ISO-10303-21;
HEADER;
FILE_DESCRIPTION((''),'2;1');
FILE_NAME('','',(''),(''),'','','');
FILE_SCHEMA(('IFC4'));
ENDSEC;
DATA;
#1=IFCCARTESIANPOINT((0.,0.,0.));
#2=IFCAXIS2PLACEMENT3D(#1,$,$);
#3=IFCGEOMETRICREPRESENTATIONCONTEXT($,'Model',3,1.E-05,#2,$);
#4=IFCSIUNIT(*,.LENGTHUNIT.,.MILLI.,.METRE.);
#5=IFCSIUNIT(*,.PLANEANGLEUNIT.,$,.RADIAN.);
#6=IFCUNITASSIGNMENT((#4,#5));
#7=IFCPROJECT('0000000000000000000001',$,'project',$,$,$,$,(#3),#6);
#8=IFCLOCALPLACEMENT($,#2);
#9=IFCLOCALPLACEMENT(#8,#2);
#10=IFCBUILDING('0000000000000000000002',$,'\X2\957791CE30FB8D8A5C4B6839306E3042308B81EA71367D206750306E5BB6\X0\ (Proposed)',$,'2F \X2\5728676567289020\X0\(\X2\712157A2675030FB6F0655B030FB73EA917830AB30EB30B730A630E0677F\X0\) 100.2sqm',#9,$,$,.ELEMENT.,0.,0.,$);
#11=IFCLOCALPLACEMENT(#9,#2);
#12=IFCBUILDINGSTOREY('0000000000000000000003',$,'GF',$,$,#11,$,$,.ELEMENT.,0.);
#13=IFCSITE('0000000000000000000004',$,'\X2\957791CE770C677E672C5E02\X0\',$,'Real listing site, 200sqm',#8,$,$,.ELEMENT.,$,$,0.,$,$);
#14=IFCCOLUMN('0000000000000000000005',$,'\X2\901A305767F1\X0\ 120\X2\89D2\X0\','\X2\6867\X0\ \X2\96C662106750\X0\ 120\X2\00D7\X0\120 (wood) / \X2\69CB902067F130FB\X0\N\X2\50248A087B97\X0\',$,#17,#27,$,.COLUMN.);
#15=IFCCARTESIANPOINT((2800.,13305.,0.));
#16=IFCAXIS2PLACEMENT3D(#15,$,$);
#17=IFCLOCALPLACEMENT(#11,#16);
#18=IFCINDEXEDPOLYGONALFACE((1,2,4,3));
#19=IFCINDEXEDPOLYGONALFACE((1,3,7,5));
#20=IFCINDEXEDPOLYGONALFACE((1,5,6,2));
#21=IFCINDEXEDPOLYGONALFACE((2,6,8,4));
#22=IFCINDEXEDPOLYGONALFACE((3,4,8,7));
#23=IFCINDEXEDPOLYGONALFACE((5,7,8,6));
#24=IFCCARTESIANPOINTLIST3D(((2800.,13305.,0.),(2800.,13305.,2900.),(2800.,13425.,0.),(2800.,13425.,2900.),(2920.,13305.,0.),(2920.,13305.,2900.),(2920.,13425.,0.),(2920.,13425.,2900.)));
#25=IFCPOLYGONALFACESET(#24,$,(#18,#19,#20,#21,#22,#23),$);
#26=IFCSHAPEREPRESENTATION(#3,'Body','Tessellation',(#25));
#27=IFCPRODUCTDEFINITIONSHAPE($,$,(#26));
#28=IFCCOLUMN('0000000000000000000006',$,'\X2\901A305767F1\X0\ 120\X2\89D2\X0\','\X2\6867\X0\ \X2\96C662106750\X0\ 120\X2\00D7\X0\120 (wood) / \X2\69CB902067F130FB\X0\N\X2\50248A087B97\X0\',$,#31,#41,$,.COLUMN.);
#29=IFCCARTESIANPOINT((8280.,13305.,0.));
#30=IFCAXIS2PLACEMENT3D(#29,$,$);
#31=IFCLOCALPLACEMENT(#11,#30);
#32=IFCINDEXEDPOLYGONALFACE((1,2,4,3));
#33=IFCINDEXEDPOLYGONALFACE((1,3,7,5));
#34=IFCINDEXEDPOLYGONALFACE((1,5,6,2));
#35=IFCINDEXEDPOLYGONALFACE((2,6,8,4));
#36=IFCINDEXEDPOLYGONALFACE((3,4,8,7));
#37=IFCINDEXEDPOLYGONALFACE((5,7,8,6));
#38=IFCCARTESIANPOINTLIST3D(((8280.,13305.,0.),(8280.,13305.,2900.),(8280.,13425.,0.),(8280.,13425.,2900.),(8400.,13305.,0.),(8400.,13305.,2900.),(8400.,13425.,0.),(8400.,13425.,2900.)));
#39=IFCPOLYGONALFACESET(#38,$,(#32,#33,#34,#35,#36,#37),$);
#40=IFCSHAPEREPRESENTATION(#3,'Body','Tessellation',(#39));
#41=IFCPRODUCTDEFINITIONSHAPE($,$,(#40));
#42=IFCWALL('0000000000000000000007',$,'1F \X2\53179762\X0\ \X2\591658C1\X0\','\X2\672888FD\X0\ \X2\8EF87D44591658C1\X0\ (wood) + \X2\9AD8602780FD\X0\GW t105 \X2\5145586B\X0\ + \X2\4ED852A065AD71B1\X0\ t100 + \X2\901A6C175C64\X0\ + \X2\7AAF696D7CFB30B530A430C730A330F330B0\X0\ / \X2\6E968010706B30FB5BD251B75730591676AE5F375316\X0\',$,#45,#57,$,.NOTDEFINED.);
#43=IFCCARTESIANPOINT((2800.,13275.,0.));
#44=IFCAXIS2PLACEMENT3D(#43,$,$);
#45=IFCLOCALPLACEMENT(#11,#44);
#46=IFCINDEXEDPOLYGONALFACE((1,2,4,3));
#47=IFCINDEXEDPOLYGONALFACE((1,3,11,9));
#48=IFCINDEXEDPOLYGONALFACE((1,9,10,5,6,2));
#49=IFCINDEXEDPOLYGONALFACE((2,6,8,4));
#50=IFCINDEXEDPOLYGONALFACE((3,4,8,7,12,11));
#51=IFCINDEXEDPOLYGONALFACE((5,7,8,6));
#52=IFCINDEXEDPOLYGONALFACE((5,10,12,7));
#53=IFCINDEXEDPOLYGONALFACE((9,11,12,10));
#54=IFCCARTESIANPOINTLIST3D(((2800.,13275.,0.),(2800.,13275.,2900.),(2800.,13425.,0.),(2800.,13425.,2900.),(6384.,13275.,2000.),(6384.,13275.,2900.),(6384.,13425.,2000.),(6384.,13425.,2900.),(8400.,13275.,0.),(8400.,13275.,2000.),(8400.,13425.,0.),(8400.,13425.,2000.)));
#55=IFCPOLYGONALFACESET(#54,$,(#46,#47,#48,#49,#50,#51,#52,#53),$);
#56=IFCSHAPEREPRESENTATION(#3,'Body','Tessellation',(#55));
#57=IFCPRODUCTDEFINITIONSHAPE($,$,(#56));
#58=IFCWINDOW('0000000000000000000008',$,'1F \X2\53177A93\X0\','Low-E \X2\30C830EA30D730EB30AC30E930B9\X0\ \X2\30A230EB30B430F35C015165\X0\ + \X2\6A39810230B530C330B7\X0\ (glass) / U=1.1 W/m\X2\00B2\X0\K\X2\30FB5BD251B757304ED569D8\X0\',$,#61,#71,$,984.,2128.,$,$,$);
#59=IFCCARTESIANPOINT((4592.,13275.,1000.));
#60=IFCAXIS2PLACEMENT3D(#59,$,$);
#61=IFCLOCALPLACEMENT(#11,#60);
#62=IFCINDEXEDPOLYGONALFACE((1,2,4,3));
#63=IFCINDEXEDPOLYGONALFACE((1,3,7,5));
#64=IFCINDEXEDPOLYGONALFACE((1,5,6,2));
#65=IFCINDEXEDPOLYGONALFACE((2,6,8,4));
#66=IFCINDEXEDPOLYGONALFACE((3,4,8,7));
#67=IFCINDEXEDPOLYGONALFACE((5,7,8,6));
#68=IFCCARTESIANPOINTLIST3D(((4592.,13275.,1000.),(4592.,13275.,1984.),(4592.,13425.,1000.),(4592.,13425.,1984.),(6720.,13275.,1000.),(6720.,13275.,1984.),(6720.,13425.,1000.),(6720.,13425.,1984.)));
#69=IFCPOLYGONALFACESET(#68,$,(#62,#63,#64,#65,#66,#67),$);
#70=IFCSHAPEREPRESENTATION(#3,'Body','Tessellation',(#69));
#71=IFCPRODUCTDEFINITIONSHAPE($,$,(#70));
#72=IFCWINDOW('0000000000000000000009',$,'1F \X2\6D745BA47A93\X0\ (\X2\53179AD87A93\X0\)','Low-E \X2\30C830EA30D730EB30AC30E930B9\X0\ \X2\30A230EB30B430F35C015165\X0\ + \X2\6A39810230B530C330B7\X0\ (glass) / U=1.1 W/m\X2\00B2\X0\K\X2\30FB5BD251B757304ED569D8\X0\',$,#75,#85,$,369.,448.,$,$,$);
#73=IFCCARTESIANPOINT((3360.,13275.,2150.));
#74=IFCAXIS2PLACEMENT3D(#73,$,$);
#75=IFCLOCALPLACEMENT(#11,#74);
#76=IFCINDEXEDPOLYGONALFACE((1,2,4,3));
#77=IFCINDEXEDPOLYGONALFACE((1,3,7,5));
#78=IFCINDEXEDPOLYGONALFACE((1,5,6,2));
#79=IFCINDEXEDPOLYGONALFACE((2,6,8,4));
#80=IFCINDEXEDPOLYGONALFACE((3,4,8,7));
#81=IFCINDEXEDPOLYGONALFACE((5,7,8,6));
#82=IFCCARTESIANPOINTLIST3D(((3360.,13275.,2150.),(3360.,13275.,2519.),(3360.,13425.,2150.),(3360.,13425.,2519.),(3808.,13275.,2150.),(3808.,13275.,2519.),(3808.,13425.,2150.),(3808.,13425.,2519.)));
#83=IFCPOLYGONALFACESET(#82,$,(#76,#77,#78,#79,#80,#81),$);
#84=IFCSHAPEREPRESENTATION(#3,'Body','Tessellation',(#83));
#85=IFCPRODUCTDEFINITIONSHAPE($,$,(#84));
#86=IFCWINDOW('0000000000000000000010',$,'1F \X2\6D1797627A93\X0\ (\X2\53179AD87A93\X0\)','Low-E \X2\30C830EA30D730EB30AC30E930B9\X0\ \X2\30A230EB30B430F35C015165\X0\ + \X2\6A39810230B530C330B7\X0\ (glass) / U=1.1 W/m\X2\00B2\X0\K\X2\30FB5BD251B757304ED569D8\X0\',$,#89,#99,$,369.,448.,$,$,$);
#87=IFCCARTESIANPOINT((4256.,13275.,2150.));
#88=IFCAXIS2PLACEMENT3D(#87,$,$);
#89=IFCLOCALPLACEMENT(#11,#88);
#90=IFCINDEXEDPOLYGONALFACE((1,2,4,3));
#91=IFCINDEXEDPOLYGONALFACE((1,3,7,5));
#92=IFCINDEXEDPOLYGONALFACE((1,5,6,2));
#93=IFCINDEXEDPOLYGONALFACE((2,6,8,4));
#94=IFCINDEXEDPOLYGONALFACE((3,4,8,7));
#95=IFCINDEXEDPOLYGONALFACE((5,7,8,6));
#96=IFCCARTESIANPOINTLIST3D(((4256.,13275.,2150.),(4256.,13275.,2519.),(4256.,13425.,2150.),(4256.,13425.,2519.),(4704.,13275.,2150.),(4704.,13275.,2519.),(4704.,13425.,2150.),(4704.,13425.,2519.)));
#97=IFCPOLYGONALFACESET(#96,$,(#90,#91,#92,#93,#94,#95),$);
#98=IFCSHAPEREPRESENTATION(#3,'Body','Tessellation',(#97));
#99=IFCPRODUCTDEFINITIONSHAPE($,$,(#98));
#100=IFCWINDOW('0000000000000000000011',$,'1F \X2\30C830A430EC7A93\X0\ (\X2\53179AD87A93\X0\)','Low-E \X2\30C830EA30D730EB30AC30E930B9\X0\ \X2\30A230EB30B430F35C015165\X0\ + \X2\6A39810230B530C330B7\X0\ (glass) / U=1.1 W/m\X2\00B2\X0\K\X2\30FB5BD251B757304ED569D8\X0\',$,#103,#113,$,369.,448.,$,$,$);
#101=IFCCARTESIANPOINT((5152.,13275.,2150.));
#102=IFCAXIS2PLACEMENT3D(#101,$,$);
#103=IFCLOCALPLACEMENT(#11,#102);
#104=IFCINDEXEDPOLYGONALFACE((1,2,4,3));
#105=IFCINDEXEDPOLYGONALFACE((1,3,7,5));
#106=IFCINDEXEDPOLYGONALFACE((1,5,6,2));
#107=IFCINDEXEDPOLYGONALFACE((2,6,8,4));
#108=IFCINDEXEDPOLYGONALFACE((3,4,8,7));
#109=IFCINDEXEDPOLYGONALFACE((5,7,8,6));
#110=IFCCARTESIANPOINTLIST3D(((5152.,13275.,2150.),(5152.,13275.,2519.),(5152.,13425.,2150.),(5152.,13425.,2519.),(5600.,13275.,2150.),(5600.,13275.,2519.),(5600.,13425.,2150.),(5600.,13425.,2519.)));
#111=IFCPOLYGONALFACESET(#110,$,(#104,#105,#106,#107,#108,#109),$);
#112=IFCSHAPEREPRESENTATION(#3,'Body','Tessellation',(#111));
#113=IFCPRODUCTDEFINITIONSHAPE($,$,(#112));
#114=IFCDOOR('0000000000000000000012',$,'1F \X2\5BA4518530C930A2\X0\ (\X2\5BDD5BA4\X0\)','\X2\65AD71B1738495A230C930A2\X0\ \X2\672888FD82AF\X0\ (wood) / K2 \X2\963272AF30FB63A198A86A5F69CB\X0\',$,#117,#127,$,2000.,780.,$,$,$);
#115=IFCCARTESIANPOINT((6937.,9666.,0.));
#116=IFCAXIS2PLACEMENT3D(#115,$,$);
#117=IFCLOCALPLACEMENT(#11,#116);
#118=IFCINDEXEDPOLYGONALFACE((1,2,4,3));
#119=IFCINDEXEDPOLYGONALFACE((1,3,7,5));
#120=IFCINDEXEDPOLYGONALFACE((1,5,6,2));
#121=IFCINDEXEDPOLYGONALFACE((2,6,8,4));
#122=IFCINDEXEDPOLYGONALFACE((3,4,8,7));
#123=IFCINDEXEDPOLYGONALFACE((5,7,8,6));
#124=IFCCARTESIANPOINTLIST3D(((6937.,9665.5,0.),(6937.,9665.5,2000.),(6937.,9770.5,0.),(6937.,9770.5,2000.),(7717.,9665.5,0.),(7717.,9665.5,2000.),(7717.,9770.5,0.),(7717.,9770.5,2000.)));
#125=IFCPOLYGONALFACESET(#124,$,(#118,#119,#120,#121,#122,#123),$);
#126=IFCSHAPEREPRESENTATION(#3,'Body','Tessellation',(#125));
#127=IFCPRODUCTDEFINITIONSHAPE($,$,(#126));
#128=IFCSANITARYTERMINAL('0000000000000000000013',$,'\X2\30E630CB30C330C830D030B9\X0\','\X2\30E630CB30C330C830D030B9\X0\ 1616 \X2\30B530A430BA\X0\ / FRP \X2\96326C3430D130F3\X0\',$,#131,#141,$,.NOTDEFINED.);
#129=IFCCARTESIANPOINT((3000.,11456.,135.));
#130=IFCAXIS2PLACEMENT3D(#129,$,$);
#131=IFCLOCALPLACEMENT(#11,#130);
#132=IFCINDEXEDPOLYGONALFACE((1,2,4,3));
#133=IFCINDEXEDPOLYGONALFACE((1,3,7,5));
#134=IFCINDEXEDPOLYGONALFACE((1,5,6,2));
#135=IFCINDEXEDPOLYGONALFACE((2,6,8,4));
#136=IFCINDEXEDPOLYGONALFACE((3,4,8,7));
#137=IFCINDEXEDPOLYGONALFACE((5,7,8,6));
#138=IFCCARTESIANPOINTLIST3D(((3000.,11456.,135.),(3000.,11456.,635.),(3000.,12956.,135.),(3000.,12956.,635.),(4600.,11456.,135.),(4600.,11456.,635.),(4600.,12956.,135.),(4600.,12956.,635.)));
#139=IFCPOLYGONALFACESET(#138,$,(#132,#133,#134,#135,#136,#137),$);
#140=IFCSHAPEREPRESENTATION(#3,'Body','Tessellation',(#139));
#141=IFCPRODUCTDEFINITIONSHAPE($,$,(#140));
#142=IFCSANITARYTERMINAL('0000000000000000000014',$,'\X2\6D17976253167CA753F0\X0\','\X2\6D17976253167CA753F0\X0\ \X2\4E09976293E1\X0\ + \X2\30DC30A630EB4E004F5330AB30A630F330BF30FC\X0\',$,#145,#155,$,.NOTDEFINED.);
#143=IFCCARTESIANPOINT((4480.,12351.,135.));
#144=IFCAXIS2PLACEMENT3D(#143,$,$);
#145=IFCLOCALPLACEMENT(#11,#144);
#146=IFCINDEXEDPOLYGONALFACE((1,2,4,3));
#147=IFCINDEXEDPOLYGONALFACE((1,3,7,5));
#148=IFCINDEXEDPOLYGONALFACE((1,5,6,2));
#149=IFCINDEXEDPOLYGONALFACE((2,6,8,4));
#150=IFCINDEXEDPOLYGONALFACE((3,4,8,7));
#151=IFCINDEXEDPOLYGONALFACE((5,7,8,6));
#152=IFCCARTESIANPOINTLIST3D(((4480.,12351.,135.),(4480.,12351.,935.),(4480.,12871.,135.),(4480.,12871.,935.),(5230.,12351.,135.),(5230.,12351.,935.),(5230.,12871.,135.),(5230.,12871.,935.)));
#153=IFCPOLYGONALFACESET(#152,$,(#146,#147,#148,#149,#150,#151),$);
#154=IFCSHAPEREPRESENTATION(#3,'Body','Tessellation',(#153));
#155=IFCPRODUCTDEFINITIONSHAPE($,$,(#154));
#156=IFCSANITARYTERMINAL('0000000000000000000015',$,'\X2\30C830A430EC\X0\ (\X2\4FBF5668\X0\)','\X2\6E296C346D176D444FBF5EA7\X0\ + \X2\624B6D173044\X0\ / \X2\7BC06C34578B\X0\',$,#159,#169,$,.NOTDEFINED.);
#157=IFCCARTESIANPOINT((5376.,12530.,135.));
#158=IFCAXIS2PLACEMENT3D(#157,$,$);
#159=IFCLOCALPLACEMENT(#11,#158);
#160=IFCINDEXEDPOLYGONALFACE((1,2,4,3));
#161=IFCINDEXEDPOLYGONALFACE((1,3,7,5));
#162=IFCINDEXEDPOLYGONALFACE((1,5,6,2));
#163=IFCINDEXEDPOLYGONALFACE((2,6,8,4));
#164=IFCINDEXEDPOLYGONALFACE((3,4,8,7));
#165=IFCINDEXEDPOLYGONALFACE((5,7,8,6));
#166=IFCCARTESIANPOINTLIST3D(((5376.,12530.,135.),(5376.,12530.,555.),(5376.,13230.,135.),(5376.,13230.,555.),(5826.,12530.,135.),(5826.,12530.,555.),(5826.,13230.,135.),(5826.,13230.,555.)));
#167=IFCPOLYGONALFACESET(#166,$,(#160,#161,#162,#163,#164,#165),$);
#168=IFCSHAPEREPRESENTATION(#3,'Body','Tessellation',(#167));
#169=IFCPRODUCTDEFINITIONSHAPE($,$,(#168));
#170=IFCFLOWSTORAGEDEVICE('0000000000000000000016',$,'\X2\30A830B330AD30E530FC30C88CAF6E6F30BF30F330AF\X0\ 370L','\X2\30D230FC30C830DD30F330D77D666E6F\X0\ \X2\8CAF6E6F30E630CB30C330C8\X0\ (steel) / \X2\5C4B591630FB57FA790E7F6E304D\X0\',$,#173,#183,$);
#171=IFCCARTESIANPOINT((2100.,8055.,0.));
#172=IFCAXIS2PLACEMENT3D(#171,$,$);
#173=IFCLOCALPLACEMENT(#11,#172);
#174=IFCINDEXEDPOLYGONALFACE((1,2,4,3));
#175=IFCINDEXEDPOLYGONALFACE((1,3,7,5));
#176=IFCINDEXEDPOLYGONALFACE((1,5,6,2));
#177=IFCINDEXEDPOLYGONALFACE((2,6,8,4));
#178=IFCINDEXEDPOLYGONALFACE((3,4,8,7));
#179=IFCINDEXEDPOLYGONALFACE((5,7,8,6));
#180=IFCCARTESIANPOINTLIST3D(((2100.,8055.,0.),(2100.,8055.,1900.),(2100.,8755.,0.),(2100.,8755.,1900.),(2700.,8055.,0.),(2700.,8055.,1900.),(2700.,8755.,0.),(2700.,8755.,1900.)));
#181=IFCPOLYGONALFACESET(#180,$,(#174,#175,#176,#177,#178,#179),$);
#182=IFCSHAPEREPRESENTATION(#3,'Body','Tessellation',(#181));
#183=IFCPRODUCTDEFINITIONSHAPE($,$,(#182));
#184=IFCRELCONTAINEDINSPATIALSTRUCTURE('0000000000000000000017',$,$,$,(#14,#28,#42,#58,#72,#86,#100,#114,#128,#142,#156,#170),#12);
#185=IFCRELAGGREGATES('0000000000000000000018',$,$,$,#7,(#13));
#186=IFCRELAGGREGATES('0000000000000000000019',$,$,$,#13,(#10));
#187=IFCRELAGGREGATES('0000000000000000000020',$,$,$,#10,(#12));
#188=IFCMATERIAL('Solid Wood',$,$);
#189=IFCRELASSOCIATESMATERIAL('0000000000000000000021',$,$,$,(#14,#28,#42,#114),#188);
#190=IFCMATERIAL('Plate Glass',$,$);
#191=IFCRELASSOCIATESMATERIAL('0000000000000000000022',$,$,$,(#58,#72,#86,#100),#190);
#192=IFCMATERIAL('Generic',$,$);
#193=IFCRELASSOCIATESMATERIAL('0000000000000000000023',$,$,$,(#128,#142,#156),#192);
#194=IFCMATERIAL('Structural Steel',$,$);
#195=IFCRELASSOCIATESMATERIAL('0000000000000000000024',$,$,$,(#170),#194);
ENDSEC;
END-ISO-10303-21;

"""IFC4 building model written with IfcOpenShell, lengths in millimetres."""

from ifc_helpers import new_model, si_unit, frame, frame_2d, origin, place, context, project, spatial, rectangle, extrude, material, element, fill, save


model = new_model("IFC4")

# Units and contexts
model_context = context("Model", 3, precision=1e-05, world=origin())
ifc_project = project(units=[si_unit("LENGTHUNIT", "METRE", prefix="MILLI"), si_unit("PLANEANGLEUNIT", "RADIAN")], contexts=[model_context])

# Site, building, storey
site_placement = place(None, origin())
site = spatial("IfcSite", under=ifc_project, at=site_placement, Name="長野県松本市", ObjectType="Real listing site, 200sqm", CompositionType="ELEMENT", RefElevation=0.0)
building_placement = place(site_placement, origin())
building = spatial("IfcBuilding", under=site, at=building_placement, Name="長野・越屋根のある自然素材の家 (Proposed)", ObjectType="2F 在来木造(無垢材・漆喰・珪酸カルシウム板) 100.2sqm", CompositionType="ELEMENT", ElevationOfRefHeight=0.0, ElevationOfTerrain=0.0)
storey_placement = place(building_placement, origin())
storey = spatial("IfcBuildingStorey", under=building, at=storey_placement, Name="GF", CompositionType="ELEMENT", Elevation=0.0)

# Columns
ifc_material_1 = material(Name="Solid Wood")
column_1_placement = place(storey_placement, frame((2800.0, 13305.0, 0.0)))
element("IfcColumn", 1, at=column_1_placement, inside=storey, material=ifc_material_1, Name="通し柱 120角", Description="桧 集成材 120×120 (wood) / 構造柱・N値計算", PredefinedType="COLUMN", context=model_context, shape_type="SweptSolid", body=[
    extrude(rectangle(XDim=120.0, YDim=120.0, at=frame_2d((60.0, 60.0))), frame((2800.0, 13305.0, 0.0)), (0.0, 0.0, 1.0), 2900.0),
])
column_2_placement = place(storey_placement, frame((8280.0, 13305.0, 0.0)))
element("IfcColumn", 2, at=column_2_placement, inside=storey, material=ifc_material_1, Name="通し柱 120角", Description="桧 集成材 120×120 (wood) / 構造柱・N値計算", PredefinedType="COLUMN", context=model_context, shape_type="SweptSolid", body=[
    extrude(rectangle(XDim=120.0, YDim=120.0, at=frame_2d((60.0, 60.0))), frame((8280.0, 13305.0, 0.0)), (0.0, 0.0, 1.0), 2900.0),
])

# Wall, openings, windows
wall_1_placement = place(storey_placement, frame((2800.0, 13275.0, 0.0)))
wall_1 = element("IfcWall", 3, at=wall_1_placement, inside=storey, material=ifc_material_1, Name="1F 北面 外壁", Description="木製 軸組外壁 (wood) + 高性能GW t105 充填 + 付加断熱 t100 + 通気層 + 窯業系サイディング / 準耐火・寒冷地外皮強化", PredefinedType="NOTDEFINED", context=model_context, shape_type="SweptSolid", body=[
    extrude(rectangle(XDim=5600.0, YDim=150.0, at=frame_2d((2800.0, 75.0))), frame((2800.0, 13275.0, 0.0)), (0.0, 0.0, 1.0), 2900.0),
])
opening_1_placement = place(storey_placement, frame((4592.0, 13275.0, 1000.0)))
opening_1 = element("IfcOpeningElement", 4, at=opening_1_placement, cuts=wall_1, PredefinedType="NOTDEFINED", context=model_context, shape_type="SweptSolid", body=[
    extrude(rectangle(XDim=2128.0, YDim=150.0, at=frame_2d((1064.0, 75.0))), frame((4592.0, 13275.0, 1000.0)), (0.0, 0.0, 1.0), 984.0),
])
opening_2_placement = place(storey_placement, frame((3360.0, 13275.0, 2150.0)))
opening_2 = element("IfcOpeningElement", 5, at=opening_2_placement, cuts=wall_1, PredefinedType="NOTDEFINED", context=model_context, shape_type="SweptSolid", body=[
    extrude(rectangle(XDim=448.0, YDim=150.0, at=frame_2d((224.0, 75.0))), frame((3360.0, 13275.0, 2150.0)), (0.0, 0.0, 1.0), 369.0),
])
opening_3_placement = place(storey_placement, frame((4256.0, 13275.0, 2150.0)))
opening_3 = element("IfcOpeningElement", 6, at=opening_3_placement, cuts=wall_1, PredefinedType="NOTDEFINED", context=model_context, shape_type="SweptSolid", body=[
    extrude(rectangle(XDim=448.0, YDim=150.0, at=frame_2d((224.0, 75.0))), frame((4256.0, 13275.0, 2150.0)), (0.0, 0.0, 1.0), 369.0),
])
opening_4_placement = place(storey_placement, frame((5152.0, 13275.0, 2150.0)))
opening_4 = element("IfcOpeningElement", 7, at=opening_4_placement, cuts=wall_1, PredefinedType="NOTDEFINED", context=model_context, shape_type="SweptSolid", body=[
    extrude(rectangle(XDim=448.0, YDim=150.0, at=frame_2d((224.0, 75.0))), frame((5152.0, 13275.0, 2150.0)), (0.0, 0.0, 1.0), 369.0),
])
ifc_material_2 = material(Name="Plate Glass")
window_1_placement = place(storey_placement, frame((4592.0, 13275.0, 1000.0)))
window_1 = element("IfcWindow", 8, at=window_1_placement, inside=storey, material=ifc_material_2, Name="1F 北窓", Description="Low-E トリプルガラス アルゴン封入 + 樹脂サッシ (glass) / U=1.1 W/m²K・寒冷地仕様", OverallHeight=984.0, OverallWidth=2128.0, context=model_context, shape_type="SweptSolid", body=[
    extrude(rectangle(XDim=2128.0, YDim=150.0, at=frame_2d((1064.0, 75.0))), frame((4592.0, 13275.0, 1000.0)), (0.0, 0.0, 1.0), 984.0),
])
fill(opening_1, window_1)
window_2_placement = place(storey_placement, frame((3360.0, 13275.0, 2150.0)))
window_2 = element("IfcWindow", 9, at=window_2_placement, inside=storey, material=ifc_material_2, Name="1F 浴室窓 (北高窓)", Description="Low-E トリプルガラス アルゴン封入 + 樹脂サッシ (glass) / U=1.1 W/m²K・寒冷地仕様", OverallHeight=369.0, OverallWidth=448.0, context=model_context, shape_type="SweptSolid", body=[
    extrude(rectangle(XDim=448.0, YDim=150.0, at=frame_2d((224.0, 75.0))), frame((3360.0, 13275.0, 2150.0)), (0.0, 0.0, 1.0), 369.0),
])
fill(opening_2, window_2)
window_3_placement = place(storey_placement, frame((4256.0, 13275.0, 2150.0)))
window_3 = element("IfcWindow", 10, at=window_3_placement, inside=storey, material=ifc_material_2, Name="1F 洗面窓 (北高窓)", Description="Low-E トリプルガラス アルゴン封入 + 樹脂サッシ (glass) / U=1.1 W/m²K・寒冷地仕様", OverallHeight=369.0, OverallWidth=448.0, context=model_context, shape_type="SweptSolid", body=[
    extrude(rectangle(XDim=448.0, YDim=150.0, at=frame_2d((224.0, 75.0))), frame((4256.0, 13275.0, 2150.0)), (0.0, 0.0, 1.0), 369.0),
])
fill(opening_3, window_3)
window_4_placement = place(storey_placement, frame((5152.0, 13275.0, 2150.0)))
window_4 = element("IfcWindow", 11, at=window_4_placement, inside=storey, material=ifc_material_2, Name="1F トイレ窓 (北高窓)", Description="Low-E トリプルガラス アルゴン封入 + 樹脂サッシ (glass) / U=1.1 W/m²K・寒冷地仕様", OverallHeight=369.0, OverallWidth=448.0, context=model_context, shape_type="SweptSolid", body=[
    extrude(rectangle(XDim=448.0, YDim=150.0, at=frame_2d((224.0, 75.0))), frame((5152.0, 13275.0, 2150.0)), (0.0, 0.0, 1.0), 369.0),
])
fill(opening_4, window_4)

# Door
door_1_placement = place(storey_placement, frame((6937.0, 9666.0, 0.0)))
element("IfcDoor", 12, at=door_1_placement, inside=storey, material=ifc_material_1, Name="1F 室内ドア (寝室)", Description="断熱玄関ドア 木製芯 (wood) / K2 防犯・採風機構", OverallHeight=2000.0, OverallWidth=780.0, context=model_context, shape_type="SweptSolid", body=[
    extrude(rectangle(XDim=780.0, YDim=105.0, at=frame_2d((390.0, 52.0))), frame((6937.0, 9666.0, 0.0)), (0.0, 0.0, 1.0), 2000.0),
])

# Sanitary terminals
ifc_material_3 = material(Name="Generic")
sanitary_terminal_1_placement = place(storey_placement, frame((3000.0, 11456.0, 135.0)))
element("IfcSanitaryTerminal", 13, at=sanitary_terminal_1_placement, inside=storey, material=ifc_material_3, Name="ユニットバス", Description="ユニットバス 1616 サイズ / FRP 防水パン", PredefinedType="NOTDEFINED", context=model_context, shape_type="SweptSolid", body=[
    extrude(rectangle(XDim=1600.0, YDim=1500.0, at=frame_2d((800.0, 750.0))), frame((3000.0, 11456.0, 135.0)), (0.0, 0.0, 1.0), 500.0),
])
sanitary_terminal_2_placement = place(storey_placement, frame((4480.0, 12351.0, 135.0)))
element("IfcSanitaryTerminal", 14, at=sanitary_terminal_2_placement, inside=storey, material=ifc_material_3, Name="洗面化粧台", Description="洗面化粧台 三面鏡 + ボウル一体カウンター", PredefinedType="NOTDEFINED", context=model_context, shape_type="SweptSolid", body=[
    extrude(rectangle(XDim=750.0, YDim=520.0, at=frame_2d((375.0, 260.0))), frame((4480.0, 12351.0, 135.0)), (0.0, 0.0, 1.0), 800.0),
])
sanitary_terminal_3_placement = place(storey_placement, frame((5376.0, 12530.0, 135.0)))
element("IfcSanitaryTerminal", 15, at=sanitary_terminal_3_placement, inside=storey, material=ifc_material_3, Name="トイレ (便器)", Description="温水洗浄便座 + 手洗い / 節水型", PredefinedType="NOTDEFINED", context=model_context, shape_type="SweptSolid", body=[
    extrude(rectangle(XDim=450.0, YDim=700.0, at=frame_2d((225.0, 350.0))), frame((5376.0, 12530.0, 135.0)), (0.0, 0.0, 1.0), 420.0),
])

# Flow storage device
ifc_material_4 = material(Name="Structural Steel")
flow_storage_device_placement = place(storey_placement, frame((2100.0, 8055.0, 0.0)))
element("IfcFlowStorageDevice", 16, at=flow_storage_device_placement, inside=storey, material=ifc_material_4, Name="エコキュート貯湯タンク 370L", Description="ヒートポンプ給湯 貯湯ユニット (steel) / 屋外・基礎置き", context=model_context, shape_type="SweptSolid", body=[
    extrude(rectangle(XDim=600.0, YDim=700.0, at=frame_2d((300.0, 350.0))), frame((2100.0, 8055.0, 0.0)), (0.0, 0.0, 1.0), 1900.0),
])

save(model, "model.ifc")
